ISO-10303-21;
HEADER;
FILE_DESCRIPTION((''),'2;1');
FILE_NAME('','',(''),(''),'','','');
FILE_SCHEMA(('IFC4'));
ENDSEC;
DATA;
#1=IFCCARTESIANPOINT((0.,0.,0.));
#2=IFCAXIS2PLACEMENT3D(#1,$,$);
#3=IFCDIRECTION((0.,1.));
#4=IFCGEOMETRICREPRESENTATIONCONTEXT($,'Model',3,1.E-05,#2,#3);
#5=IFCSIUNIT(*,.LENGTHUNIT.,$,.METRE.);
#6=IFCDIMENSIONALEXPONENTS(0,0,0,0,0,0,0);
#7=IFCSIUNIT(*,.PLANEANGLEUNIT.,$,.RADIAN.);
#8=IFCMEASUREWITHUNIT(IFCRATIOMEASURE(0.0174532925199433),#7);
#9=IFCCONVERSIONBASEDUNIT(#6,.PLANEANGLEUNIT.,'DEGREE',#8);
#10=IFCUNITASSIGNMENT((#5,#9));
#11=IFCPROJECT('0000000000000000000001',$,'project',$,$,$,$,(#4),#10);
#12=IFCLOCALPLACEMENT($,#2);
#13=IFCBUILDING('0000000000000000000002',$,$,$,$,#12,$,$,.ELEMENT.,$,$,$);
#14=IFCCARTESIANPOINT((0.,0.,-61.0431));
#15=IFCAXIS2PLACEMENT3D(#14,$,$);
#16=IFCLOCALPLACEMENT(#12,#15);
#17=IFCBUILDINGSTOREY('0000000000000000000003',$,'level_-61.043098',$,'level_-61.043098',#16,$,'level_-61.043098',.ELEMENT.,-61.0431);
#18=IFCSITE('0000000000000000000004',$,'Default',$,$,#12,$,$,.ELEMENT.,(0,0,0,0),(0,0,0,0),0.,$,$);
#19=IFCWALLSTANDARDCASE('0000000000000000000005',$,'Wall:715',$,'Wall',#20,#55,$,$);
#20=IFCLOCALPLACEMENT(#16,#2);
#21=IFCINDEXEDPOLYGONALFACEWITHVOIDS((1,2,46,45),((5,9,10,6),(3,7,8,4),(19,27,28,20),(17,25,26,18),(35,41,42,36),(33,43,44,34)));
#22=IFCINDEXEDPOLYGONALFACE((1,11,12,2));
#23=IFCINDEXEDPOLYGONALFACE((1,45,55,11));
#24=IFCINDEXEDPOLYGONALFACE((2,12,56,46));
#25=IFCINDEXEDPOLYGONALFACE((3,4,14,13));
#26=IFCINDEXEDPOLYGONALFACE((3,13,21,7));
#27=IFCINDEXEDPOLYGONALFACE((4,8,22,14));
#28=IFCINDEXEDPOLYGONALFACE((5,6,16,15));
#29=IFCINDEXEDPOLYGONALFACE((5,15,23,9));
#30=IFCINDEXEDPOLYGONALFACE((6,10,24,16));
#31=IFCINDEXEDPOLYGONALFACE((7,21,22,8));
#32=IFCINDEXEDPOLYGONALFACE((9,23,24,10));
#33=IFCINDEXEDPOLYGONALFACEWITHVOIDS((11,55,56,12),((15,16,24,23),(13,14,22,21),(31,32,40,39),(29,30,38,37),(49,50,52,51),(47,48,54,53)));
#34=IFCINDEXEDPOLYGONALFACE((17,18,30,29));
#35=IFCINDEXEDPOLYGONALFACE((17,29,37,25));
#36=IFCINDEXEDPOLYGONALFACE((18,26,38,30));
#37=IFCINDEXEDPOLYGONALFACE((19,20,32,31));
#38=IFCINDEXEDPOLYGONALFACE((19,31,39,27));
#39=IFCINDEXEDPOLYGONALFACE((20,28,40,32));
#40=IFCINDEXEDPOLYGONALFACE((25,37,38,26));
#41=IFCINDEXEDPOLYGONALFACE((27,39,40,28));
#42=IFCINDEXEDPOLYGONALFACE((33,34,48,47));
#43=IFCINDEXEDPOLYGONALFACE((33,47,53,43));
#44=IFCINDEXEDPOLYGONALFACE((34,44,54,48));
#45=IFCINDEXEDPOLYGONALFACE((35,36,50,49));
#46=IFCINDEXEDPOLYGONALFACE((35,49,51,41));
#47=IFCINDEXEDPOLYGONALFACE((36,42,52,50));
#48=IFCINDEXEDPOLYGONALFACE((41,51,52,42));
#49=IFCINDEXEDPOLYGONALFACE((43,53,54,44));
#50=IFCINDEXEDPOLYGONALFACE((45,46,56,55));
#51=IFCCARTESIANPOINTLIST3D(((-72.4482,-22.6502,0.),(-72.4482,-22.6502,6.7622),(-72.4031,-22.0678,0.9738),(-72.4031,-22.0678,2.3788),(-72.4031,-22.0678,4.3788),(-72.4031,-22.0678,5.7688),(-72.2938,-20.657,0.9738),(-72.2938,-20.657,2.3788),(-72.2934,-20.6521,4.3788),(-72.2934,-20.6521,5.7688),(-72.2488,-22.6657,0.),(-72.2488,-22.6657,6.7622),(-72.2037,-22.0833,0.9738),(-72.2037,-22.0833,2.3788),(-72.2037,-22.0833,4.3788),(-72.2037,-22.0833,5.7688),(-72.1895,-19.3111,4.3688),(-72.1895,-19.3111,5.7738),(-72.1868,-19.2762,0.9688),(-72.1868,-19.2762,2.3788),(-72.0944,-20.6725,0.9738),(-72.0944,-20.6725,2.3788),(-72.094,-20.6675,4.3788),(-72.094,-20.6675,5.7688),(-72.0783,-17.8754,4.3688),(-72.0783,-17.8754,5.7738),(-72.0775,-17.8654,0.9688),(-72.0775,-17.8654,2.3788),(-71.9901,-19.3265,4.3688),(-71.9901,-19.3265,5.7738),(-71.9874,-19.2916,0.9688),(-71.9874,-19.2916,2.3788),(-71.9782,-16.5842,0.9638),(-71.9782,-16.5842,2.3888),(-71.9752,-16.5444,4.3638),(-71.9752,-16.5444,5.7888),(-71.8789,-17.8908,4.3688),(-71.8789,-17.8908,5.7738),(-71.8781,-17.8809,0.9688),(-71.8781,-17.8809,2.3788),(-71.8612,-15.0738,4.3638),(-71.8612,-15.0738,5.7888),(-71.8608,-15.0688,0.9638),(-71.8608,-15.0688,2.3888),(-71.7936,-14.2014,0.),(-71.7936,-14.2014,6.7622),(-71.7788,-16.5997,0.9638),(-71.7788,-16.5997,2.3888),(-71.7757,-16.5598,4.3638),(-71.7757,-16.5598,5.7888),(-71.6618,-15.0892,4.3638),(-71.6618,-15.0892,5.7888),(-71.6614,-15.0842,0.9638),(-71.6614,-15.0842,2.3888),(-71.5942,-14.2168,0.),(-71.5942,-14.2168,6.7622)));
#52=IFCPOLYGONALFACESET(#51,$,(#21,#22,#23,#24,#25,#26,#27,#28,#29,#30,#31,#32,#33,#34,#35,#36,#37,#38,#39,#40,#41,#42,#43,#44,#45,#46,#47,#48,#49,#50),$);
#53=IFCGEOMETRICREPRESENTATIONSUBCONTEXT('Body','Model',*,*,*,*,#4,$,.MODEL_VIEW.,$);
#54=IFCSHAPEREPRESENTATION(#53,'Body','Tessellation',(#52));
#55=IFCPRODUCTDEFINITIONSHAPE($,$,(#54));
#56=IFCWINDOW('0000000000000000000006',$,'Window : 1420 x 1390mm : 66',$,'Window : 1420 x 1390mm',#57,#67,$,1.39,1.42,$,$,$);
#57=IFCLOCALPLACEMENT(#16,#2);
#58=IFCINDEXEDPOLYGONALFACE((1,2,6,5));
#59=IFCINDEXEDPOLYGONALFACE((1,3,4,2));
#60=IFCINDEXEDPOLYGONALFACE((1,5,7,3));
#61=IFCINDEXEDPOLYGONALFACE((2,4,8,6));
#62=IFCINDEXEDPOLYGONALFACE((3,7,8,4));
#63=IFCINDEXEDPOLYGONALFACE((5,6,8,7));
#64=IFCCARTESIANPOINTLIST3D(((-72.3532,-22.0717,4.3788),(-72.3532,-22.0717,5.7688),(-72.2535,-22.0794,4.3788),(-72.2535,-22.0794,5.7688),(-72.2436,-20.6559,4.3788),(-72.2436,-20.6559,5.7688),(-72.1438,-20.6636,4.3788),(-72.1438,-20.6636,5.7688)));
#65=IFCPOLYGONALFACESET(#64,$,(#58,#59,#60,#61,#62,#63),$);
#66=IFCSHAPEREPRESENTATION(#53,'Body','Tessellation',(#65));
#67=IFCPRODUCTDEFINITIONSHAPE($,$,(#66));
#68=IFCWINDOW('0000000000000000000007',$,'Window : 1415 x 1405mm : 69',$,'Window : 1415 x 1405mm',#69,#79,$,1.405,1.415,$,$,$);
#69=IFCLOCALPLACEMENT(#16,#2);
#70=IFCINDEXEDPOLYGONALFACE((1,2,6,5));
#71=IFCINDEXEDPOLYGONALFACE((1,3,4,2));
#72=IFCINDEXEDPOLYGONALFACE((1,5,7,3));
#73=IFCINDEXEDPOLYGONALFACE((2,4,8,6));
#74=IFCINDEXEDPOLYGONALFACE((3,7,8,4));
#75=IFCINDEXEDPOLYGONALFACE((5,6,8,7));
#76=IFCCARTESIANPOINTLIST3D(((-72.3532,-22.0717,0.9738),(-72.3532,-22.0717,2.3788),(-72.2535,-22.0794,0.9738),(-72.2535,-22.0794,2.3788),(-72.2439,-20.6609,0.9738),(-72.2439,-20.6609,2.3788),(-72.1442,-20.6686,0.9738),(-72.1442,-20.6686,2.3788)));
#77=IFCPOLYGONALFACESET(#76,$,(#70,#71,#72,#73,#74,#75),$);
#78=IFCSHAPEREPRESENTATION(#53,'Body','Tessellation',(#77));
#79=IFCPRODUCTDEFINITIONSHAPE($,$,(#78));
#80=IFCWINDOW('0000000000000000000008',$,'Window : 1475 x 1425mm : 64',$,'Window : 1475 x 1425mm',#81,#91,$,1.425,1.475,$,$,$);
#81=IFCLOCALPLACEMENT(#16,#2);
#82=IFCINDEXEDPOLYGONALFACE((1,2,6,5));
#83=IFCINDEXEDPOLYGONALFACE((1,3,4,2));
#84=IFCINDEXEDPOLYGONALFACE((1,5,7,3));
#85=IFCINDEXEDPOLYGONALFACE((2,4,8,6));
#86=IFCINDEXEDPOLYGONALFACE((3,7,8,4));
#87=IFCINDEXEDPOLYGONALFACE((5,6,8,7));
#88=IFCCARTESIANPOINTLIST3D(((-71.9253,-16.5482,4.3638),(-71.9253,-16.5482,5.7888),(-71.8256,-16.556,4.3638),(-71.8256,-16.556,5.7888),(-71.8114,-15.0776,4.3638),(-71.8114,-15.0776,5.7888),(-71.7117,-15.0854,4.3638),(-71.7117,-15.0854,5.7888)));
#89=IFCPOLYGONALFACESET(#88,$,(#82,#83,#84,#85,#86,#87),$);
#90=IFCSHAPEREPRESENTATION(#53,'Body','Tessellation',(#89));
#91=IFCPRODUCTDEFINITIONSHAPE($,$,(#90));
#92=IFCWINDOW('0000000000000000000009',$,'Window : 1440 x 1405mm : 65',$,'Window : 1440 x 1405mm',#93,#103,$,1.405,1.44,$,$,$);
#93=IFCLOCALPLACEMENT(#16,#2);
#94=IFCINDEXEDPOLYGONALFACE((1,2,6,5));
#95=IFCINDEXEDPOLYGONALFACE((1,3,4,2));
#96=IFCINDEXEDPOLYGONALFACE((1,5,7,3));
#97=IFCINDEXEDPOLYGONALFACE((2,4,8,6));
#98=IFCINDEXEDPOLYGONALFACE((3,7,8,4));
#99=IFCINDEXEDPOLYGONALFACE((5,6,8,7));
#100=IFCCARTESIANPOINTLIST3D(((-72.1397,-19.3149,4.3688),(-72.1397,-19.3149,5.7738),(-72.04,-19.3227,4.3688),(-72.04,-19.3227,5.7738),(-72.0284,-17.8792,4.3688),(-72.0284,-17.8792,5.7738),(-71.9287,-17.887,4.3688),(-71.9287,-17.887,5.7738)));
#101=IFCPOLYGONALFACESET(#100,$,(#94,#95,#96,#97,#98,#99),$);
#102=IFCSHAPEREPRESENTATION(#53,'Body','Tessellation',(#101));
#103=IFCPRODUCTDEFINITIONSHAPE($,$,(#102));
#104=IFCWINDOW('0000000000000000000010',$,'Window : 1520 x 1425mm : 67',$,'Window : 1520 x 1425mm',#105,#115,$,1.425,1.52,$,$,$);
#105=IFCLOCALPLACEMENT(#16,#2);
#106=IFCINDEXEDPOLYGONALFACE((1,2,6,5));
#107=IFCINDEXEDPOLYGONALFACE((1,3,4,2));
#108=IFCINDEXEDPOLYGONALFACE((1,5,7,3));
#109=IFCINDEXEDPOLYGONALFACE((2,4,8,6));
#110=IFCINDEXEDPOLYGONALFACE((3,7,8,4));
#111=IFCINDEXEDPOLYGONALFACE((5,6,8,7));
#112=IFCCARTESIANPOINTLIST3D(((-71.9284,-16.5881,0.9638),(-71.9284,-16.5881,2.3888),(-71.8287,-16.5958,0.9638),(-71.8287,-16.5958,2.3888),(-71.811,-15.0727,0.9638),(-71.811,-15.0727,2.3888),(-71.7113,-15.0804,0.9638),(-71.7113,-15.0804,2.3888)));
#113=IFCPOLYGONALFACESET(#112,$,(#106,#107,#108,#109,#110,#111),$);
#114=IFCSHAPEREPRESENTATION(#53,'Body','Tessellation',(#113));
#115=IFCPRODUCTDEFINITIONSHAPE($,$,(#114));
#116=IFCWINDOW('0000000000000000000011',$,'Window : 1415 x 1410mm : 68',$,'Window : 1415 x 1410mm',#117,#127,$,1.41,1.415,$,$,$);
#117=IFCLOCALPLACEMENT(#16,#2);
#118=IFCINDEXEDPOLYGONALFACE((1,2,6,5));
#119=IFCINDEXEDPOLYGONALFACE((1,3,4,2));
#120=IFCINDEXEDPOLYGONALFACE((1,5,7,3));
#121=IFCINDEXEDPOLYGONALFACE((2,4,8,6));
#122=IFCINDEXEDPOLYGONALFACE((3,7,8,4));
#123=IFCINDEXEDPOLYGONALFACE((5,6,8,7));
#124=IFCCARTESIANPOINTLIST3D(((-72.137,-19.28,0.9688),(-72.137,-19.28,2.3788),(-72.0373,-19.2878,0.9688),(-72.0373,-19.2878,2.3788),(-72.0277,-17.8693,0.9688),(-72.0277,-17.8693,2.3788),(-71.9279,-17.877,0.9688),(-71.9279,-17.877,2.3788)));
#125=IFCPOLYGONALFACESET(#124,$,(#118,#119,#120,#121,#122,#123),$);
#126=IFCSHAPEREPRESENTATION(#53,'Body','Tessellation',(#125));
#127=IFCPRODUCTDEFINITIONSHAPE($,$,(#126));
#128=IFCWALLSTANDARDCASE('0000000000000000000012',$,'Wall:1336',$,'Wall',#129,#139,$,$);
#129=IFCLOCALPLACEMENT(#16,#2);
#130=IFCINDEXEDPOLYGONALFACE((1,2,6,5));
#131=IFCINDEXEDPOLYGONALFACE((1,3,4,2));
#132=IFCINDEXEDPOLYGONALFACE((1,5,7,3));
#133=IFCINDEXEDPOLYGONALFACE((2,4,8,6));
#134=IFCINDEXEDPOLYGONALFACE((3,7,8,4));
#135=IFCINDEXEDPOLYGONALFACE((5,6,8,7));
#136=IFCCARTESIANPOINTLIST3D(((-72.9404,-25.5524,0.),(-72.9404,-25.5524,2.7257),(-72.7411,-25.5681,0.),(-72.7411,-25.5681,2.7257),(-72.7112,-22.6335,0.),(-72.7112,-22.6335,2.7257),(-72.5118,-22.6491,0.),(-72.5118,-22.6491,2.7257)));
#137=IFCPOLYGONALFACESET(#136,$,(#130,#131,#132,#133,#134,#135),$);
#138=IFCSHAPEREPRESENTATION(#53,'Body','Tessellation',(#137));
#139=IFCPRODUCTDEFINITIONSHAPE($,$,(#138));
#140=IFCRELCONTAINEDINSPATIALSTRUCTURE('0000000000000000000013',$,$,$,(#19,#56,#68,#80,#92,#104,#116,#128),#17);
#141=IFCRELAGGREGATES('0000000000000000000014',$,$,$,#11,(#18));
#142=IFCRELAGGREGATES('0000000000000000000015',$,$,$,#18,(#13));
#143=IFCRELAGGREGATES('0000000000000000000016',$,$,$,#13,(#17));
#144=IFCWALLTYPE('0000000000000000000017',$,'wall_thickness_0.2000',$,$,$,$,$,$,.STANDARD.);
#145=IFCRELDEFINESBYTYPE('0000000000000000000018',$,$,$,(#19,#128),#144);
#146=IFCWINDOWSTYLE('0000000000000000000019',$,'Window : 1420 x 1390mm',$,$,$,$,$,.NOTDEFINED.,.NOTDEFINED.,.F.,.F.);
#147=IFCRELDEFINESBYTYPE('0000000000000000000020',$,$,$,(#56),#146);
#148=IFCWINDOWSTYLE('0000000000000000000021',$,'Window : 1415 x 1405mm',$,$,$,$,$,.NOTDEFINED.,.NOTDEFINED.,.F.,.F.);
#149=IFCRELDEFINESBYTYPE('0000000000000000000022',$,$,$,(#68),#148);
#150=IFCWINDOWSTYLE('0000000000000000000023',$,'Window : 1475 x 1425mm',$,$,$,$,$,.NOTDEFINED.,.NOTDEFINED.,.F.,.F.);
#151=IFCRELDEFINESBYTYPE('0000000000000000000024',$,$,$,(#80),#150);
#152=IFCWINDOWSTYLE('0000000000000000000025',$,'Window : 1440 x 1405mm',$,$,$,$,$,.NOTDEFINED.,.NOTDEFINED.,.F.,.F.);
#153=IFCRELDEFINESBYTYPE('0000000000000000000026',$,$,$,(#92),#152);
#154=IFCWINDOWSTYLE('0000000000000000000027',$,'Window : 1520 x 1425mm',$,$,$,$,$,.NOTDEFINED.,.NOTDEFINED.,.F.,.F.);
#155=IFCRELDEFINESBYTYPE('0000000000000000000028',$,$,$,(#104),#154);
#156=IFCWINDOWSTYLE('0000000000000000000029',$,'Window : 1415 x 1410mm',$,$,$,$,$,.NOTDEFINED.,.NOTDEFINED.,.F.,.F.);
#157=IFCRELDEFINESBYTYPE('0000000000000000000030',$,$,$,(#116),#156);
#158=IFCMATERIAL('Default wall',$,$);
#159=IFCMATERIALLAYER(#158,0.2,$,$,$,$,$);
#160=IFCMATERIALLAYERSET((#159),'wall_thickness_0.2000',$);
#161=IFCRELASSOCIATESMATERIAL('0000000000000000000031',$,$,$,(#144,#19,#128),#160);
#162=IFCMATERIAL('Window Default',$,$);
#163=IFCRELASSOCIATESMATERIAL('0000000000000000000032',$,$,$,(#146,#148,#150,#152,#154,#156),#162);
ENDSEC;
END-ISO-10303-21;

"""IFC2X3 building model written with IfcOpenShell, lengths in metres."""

from ifc_helpers import new_model, entity, si_unit, converted_unit, direction, frame, frame_2d, origin, origin_2d_with_axis, place, context, subcontext, project, spatial, polyline, rectangle, outline, extrude, source, transform, mapped, material, layer, layer_set, layer_usage, type_object, type_shapes, element, fill, save


model = new_model("IFC2X3")

# Units and contexts
model_context = context("Model", 3, precision=1e-05, world=origin(), true_north=direction((0.0, 1.0)))
body_context = subcontext(model_context, "Body", "Model", "MODEL_VIEW")
ifc_project = project(units=[si_unit("LENGTHUNIT", "METRE"), converted_unit("PLANEANGLEUNIT", "DEGREE", entity("IfcRatioMeasure", 0.0174532925199433), si_unit("PLANEANGLEUNIT", "RADIAN"), dimensions=[0, 0, 0, 0, 0, 0, 0])], contexts=[model_context])

# Site, building, storey
placement_1 = place(None, origin())
site = spatial("IfcSite", under=ifc_project, at=placement_1, Name="Default", CompositionType="ELEMENT", RefLatitude=(0, 0, 0, 0), RefLongitude=(0, 0, 0, 0), RefElevation=0.0)
building = spatial("IfcBuilding", under=site, at=placement_1, CompositionType="ELEMENT")
storey_placement = place(placement_1, frame((0.0, 0.0, -61.0431)))
storey = spatial("IfcBuildingStorey", under=building, at=storey_placement, Name="level_-61.043098", ObjectType="level_-61.043098", LongName="level_-61.043098", CompositionType="ELEMENT", Elevation=-61.0431)

# Shared definitions
ifc_material_1 = material(Name="Default wall")
ifc_layer = layer(ifc_material_1, 0.2)
ifc_layer_set = layer_set([ifc_layer], Name="wall_thickness_0.2000")
ifc_layer_usage = layer_usage(ifc_layer_set, "AXIS2", "POSITIVE", -0.1)
wall_type = type_object("IfcWallType", Name="wall_thickness_0.2000", PredefinedType="STANDARD", material=ifc_layer_set)
ifc_material_2 = material(Name="Window Default")

# Wall, openings, windows
wall_1_placement = place(storey_placement, frame((-71.6939, -14.2091, 0.0), z_axis=(0.0, 0.0, 1.0), x_axis=(-0.077245, -0.997012, 0.0)))
wall_1 = element("IfcWallStandardCase", 1, at=wall_1_placement, inside=storey, type_object=wall_type, material=ifc_layer_usage, Name="Wall:715", ObjectType="Wall", context=body_context, shape_type="SweptSolid", body=[
    extrude(outline(polyline([(8.4742, -0.1), (8.4742, 0.1), (0.0, 0.1), (0.0, -0.1), (8.4742, -0.1)])), origin(), (0.0, 0.0, 1.0), 6.7622),
])
opening_1_placement = place(wall_1_placement, frame((0.875, -0.1, 4.3638)))
opening_1 = element("IfcOpeningElement", 2, at=opening_1_placement, cuts=wall_1, ObjectType="Opening", context=body_context, shape_type="SweptSolid", body=[
    extrude(rectangle(XDim=1.475, YDim=1.425, at=frame_2d((0.7125, 0.7375), x_axis=(0.0, 1.0))), frame((0.0, 0.0, 0.0), z_axis=(0.0, 1.0, 0.0), x_axis=(0.0, 0.0, 1.0)), (0.0, 0.0, 1.0), 0.2),
])
opening_2_placement = place(wall_1_placement, frame((3.685, -0.1, 4.3688)))
opening_2 = element("IfcOpeningElement", 3, at=opening_2_placement, cuts=wall_1, ObjectType="Opening", context=body_context, shape_type="SweptSolid", body=[
    extrude(rectangle(XDim=1.44, YDim=1.405, at=frame_2d((0.7025, 0.72), x_axis=(0.0, 1.0))), frame((0.0, 0.0, 0.0), z_axis=(0.0, 1.0, 0.0), x_axis=(0.0, 0.0, 1.0)), (0.0, 0.0, 1.0), 0.2),
])
opening_3_placement = place(wall_1_placement, frame((6.47, -0.1, 4.3788)))
opening_3 = element("IfcOpeningElement", 4, at=opening_3_placement, cuts=wall_1, ObjectType="Opening", context=body_context, shape_type="SweptSolid", body=[
    extrude(rectangle(XDim=1.42, YDim=1.39, at=frame_2d((0.695, 0.71), x_axis=(0.0, 1.0))), frame((0.0, 0.0, 0.0), z_axis=(0.0, 1.0, 0.0), x_axis=(0.0, 0.0, 1.0)), (0.0, 0.0, 1.0), 0.2),
])
opening_4_placement = place(wall_1_placement, frame((0.87, -0.1, 0.9638)))
opening_4 = element("IfcOpeningElement", 5, at=opening_4_placement, cuts=wall_1, ObjectType="Opening", context=body_context, shape_type="SweptSolid", body=[
    extrude(rectangle(XDim=1.52, YDim=1.425, at=frame_2d((0.7125, 0.76), x_axis=(0.0, 1.0))), frame((0.0, 0.0, 0.0), z_axis=(0.0, 1.0, 0.0), x_axis=(0.0, 0.0, 1.0)), (0.0, 0.0, 1.0), 0.2),
])
opening_5_placement = place(wall_1_placement, frame((3.675, -0.1, 0.9688)))
opening_5 = element("IfcOpeningElement", 6, at=opening_5_placement, cuts=wall_1, ObjectType="Opening", context=body_context, shape_type="SweptSolid", body=[
    extrude(rectangle(XDim=1.415, YDim=1.41, at=frame_2d((0.705, 0.7075), x_axis=(0.0, 1.0))), frame((0.0, 0.0, 0.0), z_axis=(0.0, 1.0, 0.0), x_axis=(0.0, 0.0, 1.0)), (0.0, 0.0, 1.0), 0.2),
])
opening_6_placement = place(wall_1_placement, frame((6.475, -0.1, 0.9738)))
opening_6 = element("IfcOpeningElement", 7, at=opening_6_placement, cuts=wall_1, ObjectType="Opening", context=body_context, shape_type="SweptSolid", body=[
    extrude(rectangle(XDim=1.415, YDim=1.405, at=frame_2d((0.7025, 0.7075), x_axis=(0.0, 1.0))), frame((0.0, 0.0, 0.0), z_axis=(0.0, 1.0, 0.0), x_axis=(0.0, 0.0, 1.0)), (0.0, 0.0, 1.0), 0.2),
])
window_style_1 = type_object("IfcWindowStyle", Name="Window : 1420 x 1390mm", ConstructionType="NOTDEFINED", OperationType="NOTDEFINED", ParameterTakesPrecedence=False, Sizeable=False, material=ifc_material_2)
shared_shape_1 = source(origin(), body_context, "Body", "SweptSolid", [
    extrude(rectangle(XDim=0.1, YDim=1.42, at=origin_2d_with_axis()), frame((0.71, 0.1, 0.0), z_axis=(0.0, 0.0, 1.0), x_axis=(0.0, 1.0, 0.0)), (0.0, 0.0, 1.0), 1.39),
])
type_shapes(window_style_1, [shared_shape_1])
window_1_placement = place(opening_3_placement, origin())
window_1 = element("IfcWindow", 8, at=window_1_placement, inside=storey, type_object=window_style_1, Name="Window : 1420 x 1390mm : 66", ObjectType="Window : 1420 x 1390mm", OverallHeight=1.39, OverallWidth=1.42, context=body_context, shape_type="MappedRepresentation", body=[
    mapped(shared_shape_1, transform((0.0, 0.0, 0.0), scale=1.0)),
])
fill(opening_3, window_1)
window_style_2 = type_object("IfcWindowStyle", Name="Window : 1415 x 1405mm", ConstructionType="NOTDEFINED", OperationType="NOTDEFINED", ParameterTakesPrecedence=False, Sizeable=False, material=ifc_material_2)
shared_shape_2 = source(origin(), body_context, "Body", "SweptSolid", [
    extrude(rectangle(XDim=0.1, YDim=1.415, at=origin_2d_with_axis()), frame((0.7075, 0.1, 0.0), z_axis=(0.0, 0.0, 1.0), x_axis=(0.0, 1.0, 0.0)), (0.0, 0.0, 1.0), 1.405),
])
type_shapes(window_style_2, [shared_shape_2])
window_2_placement = place(opening_6_placement, origin())
window_2 = element("IfcWindow", 9, at=window_2_placement, inside=storey, type_object=window_style_2, Name="Window : 1415 x 1405mm : 69", ObjectType="Window : 1415 x 1405mm", OverallHeight=1.405, OverallWidth=1.415, context=body_context, shape_type="MappedRepresentation", body=[
    mapped(shared_shape_2, transform((0.0, 0.0, 0.0), scale=1.0)),
])
fill(opening_6, window_2)
window_style_3 = type_object("IfcWindowStyle", Name="Window : 1475 x 1425mm", ConstructionType="NOTDEFINED", OperationType="NOTDEFINED", ParameterTakesPrecedence=False, Sizeable=False, material=ifc_material_2)
shared_shape_3 = source(origin(), body_context, "Body", "SweptSolid", [
    extrude(rectangle(XDim=0.1, YDim=1.475, at=origin_2d_with_axis()), frame((0.7375, 0.1, 0.0), z_axis=(0.0, 0.0, 1.0), x_axis=(0.0, 1.0, 0.0)), (0.0, 0.0, 1.0), 1.425),
])
type_shapes(window_style_3, [shared_shape_3])
window_3_placement = place(opening_1_placement, origin())
window_3 = element("IfcWindow", 10, at=window_3_placement, inside=storey, type_object=window_style_3, Name="Window : 1475 x 1425mm : 64", ObjectType="Window : 1475 x 1425mm", OverallHeight=1.425, OverallWidth=1.475, context=body_context, shape_type="MappedRepresentation", body=[
    mapped(shared_shape_3, transform((0.0, 0.0, 0.0), scale=1.0)),
])
fill(opening_1, window_3)
window_style_4 = type_object("IfcWindowStyle", Name="Window : 1440 x 1405mm", ConstructionType="NOTDEFINED", OperationType="NOTDEFINED", ParameterTakesPrecedence=False, Sizeable=False, material=ifc_material_2)
shared_shape_4 = source(origin(), body_context, "Body", "SweptSolid", [
    extrude(rectangle(XDim=0.1, YDim=1.44, at=origin_2d_with_axis()), frame((0.72, 0.1, 0.0), z_axis=(0.0, 0.0, 1.0), x_axis=(0.0, 1.0, 0.0)), (0.0, 0.0, 1.0), 1.405),
])
type_shapes(window_style_4, [shared_shape_4])
window_4_placement = place(opening_2_placement, origin())
window_4 = element("IfcWindow", 11, at=window_4_placement, inside=storey, type_object=window_style_4, Name="Window : 1440 x 1405mm : 65", ObjectType="Window : 1440 x 1405mm", OverallHeight=1.405, OverallWidth=1.44, context=body_context, shape_type="MappedRepresentation", body=[
    mapped(shared_shape_4, transform((0.0, 0.0, 0.0), scale=1.0)),
])
fill(opening_2, window_4)
window_style_5 = type_object("IfcWindowStyle", Name="Window : 1520 x 1425mm", ConstructionType="NOTDEFINED", OperationType="NOTDEFINED", ParameterTakesPrecedence=False, Sizeable=False, material=ifc_material_2)
shared_shape_5 = source(origin(), body_context, "Body", "SweptSolid", [
    extrude(rectangle(XDim=0.1, YDim=1.52, at=origin_2d_with_axis()), frame((0.76, 0.1, 0.0), z_axis=(0.0, 0.0, 1.0), x_axis=(0.0, 1.0, 0.0)), (0.0, 0.0, 1.0), 1.425),
])
type_shapes(window_style_5, [shared_shape_5])
window_5_placement = place(opening_4_placement, origin())
window_5 = element("IfcWindow", 12, at=window_5_placement, inside=storey, type_object=window_style_5, Name="Window : 1520 x 1425mm : 67", ObjectType="Window : 1520 x 1425mm", OverallHeight=1.425, OverallWidth=1.52, context=body_context, shape_type="MappedRepresentation", body=[
    mapped(shared_shape_5, transform((0.0, 0.0, 0.0), scale=1.0)),
])
fill(opening_4, window_5)
window_style_6 = type_object("IfcWindowStyle", Name="Window : 1415 x 1410mm", ConstructionType="NOTDEFINED", OperationType="NOTDEFINED", ParameterTakesPrecedence=False, Sizeable=False, material=ifc_material_2)
shared_shape_6 = source(origin(), body_context, "Body", "SweptSolid", [
    extrude(rectangle(XDim=0.1, YDim=1.415, at=origin_2d_with_axis()), frame((0.7075, 0.1, 0.0), z_axis=(0.0, 0.0, 1.0), x_axis=(0.0, 1.0, 0.0)), (0.0, 0.0, 1.0), 1.41),
])
type_shapes(window_style_6, [shared_shape_6])
window_6_placement = place(opening_5_placement, origin())
window_6 = element("IfcWindow", 13, at=window_6_placement, inside=storey, type_object=window_style_6, Name="Window : 1415 x 1410mm : 68", ObjectType="Window : 1415 x 1410mm", OverallHeight=1.41, OverallWidth=1.415, context=body_context, shape_type="MappedRepresentation", body=[
    mapped(shared_shape_6, transform((0.0, 0.0, 0.0), scale=1.0)),
])
fill(opening_5, window_6)

# Wall
wall_2_placement = place(storey_placement, frame((-72.6115, -22.6413, 0.0), z_axis=(0.0, 0.0, 1.0), x_axis=(-0.078302, -0.99693, 0.0)))
element("IfcWallStandardCase", 14, at=wall_2_placement, inside=storey, type_object=wall_type, material=ifc_layer_usage, Name="Wall:1336", ObjectType="Wall", context=body_context, shape_type="SweptSolid", body=[
    extrude(outline(polyline([(2.9279, -0.1), (2.9279, 0.1), (0.0, 0.1), (0.0, -0.1), (2.9279, -0.1)])), origin(), (0.0, 0.0, 1.0), 2.7257),
])

save(model, "model.ifc")
